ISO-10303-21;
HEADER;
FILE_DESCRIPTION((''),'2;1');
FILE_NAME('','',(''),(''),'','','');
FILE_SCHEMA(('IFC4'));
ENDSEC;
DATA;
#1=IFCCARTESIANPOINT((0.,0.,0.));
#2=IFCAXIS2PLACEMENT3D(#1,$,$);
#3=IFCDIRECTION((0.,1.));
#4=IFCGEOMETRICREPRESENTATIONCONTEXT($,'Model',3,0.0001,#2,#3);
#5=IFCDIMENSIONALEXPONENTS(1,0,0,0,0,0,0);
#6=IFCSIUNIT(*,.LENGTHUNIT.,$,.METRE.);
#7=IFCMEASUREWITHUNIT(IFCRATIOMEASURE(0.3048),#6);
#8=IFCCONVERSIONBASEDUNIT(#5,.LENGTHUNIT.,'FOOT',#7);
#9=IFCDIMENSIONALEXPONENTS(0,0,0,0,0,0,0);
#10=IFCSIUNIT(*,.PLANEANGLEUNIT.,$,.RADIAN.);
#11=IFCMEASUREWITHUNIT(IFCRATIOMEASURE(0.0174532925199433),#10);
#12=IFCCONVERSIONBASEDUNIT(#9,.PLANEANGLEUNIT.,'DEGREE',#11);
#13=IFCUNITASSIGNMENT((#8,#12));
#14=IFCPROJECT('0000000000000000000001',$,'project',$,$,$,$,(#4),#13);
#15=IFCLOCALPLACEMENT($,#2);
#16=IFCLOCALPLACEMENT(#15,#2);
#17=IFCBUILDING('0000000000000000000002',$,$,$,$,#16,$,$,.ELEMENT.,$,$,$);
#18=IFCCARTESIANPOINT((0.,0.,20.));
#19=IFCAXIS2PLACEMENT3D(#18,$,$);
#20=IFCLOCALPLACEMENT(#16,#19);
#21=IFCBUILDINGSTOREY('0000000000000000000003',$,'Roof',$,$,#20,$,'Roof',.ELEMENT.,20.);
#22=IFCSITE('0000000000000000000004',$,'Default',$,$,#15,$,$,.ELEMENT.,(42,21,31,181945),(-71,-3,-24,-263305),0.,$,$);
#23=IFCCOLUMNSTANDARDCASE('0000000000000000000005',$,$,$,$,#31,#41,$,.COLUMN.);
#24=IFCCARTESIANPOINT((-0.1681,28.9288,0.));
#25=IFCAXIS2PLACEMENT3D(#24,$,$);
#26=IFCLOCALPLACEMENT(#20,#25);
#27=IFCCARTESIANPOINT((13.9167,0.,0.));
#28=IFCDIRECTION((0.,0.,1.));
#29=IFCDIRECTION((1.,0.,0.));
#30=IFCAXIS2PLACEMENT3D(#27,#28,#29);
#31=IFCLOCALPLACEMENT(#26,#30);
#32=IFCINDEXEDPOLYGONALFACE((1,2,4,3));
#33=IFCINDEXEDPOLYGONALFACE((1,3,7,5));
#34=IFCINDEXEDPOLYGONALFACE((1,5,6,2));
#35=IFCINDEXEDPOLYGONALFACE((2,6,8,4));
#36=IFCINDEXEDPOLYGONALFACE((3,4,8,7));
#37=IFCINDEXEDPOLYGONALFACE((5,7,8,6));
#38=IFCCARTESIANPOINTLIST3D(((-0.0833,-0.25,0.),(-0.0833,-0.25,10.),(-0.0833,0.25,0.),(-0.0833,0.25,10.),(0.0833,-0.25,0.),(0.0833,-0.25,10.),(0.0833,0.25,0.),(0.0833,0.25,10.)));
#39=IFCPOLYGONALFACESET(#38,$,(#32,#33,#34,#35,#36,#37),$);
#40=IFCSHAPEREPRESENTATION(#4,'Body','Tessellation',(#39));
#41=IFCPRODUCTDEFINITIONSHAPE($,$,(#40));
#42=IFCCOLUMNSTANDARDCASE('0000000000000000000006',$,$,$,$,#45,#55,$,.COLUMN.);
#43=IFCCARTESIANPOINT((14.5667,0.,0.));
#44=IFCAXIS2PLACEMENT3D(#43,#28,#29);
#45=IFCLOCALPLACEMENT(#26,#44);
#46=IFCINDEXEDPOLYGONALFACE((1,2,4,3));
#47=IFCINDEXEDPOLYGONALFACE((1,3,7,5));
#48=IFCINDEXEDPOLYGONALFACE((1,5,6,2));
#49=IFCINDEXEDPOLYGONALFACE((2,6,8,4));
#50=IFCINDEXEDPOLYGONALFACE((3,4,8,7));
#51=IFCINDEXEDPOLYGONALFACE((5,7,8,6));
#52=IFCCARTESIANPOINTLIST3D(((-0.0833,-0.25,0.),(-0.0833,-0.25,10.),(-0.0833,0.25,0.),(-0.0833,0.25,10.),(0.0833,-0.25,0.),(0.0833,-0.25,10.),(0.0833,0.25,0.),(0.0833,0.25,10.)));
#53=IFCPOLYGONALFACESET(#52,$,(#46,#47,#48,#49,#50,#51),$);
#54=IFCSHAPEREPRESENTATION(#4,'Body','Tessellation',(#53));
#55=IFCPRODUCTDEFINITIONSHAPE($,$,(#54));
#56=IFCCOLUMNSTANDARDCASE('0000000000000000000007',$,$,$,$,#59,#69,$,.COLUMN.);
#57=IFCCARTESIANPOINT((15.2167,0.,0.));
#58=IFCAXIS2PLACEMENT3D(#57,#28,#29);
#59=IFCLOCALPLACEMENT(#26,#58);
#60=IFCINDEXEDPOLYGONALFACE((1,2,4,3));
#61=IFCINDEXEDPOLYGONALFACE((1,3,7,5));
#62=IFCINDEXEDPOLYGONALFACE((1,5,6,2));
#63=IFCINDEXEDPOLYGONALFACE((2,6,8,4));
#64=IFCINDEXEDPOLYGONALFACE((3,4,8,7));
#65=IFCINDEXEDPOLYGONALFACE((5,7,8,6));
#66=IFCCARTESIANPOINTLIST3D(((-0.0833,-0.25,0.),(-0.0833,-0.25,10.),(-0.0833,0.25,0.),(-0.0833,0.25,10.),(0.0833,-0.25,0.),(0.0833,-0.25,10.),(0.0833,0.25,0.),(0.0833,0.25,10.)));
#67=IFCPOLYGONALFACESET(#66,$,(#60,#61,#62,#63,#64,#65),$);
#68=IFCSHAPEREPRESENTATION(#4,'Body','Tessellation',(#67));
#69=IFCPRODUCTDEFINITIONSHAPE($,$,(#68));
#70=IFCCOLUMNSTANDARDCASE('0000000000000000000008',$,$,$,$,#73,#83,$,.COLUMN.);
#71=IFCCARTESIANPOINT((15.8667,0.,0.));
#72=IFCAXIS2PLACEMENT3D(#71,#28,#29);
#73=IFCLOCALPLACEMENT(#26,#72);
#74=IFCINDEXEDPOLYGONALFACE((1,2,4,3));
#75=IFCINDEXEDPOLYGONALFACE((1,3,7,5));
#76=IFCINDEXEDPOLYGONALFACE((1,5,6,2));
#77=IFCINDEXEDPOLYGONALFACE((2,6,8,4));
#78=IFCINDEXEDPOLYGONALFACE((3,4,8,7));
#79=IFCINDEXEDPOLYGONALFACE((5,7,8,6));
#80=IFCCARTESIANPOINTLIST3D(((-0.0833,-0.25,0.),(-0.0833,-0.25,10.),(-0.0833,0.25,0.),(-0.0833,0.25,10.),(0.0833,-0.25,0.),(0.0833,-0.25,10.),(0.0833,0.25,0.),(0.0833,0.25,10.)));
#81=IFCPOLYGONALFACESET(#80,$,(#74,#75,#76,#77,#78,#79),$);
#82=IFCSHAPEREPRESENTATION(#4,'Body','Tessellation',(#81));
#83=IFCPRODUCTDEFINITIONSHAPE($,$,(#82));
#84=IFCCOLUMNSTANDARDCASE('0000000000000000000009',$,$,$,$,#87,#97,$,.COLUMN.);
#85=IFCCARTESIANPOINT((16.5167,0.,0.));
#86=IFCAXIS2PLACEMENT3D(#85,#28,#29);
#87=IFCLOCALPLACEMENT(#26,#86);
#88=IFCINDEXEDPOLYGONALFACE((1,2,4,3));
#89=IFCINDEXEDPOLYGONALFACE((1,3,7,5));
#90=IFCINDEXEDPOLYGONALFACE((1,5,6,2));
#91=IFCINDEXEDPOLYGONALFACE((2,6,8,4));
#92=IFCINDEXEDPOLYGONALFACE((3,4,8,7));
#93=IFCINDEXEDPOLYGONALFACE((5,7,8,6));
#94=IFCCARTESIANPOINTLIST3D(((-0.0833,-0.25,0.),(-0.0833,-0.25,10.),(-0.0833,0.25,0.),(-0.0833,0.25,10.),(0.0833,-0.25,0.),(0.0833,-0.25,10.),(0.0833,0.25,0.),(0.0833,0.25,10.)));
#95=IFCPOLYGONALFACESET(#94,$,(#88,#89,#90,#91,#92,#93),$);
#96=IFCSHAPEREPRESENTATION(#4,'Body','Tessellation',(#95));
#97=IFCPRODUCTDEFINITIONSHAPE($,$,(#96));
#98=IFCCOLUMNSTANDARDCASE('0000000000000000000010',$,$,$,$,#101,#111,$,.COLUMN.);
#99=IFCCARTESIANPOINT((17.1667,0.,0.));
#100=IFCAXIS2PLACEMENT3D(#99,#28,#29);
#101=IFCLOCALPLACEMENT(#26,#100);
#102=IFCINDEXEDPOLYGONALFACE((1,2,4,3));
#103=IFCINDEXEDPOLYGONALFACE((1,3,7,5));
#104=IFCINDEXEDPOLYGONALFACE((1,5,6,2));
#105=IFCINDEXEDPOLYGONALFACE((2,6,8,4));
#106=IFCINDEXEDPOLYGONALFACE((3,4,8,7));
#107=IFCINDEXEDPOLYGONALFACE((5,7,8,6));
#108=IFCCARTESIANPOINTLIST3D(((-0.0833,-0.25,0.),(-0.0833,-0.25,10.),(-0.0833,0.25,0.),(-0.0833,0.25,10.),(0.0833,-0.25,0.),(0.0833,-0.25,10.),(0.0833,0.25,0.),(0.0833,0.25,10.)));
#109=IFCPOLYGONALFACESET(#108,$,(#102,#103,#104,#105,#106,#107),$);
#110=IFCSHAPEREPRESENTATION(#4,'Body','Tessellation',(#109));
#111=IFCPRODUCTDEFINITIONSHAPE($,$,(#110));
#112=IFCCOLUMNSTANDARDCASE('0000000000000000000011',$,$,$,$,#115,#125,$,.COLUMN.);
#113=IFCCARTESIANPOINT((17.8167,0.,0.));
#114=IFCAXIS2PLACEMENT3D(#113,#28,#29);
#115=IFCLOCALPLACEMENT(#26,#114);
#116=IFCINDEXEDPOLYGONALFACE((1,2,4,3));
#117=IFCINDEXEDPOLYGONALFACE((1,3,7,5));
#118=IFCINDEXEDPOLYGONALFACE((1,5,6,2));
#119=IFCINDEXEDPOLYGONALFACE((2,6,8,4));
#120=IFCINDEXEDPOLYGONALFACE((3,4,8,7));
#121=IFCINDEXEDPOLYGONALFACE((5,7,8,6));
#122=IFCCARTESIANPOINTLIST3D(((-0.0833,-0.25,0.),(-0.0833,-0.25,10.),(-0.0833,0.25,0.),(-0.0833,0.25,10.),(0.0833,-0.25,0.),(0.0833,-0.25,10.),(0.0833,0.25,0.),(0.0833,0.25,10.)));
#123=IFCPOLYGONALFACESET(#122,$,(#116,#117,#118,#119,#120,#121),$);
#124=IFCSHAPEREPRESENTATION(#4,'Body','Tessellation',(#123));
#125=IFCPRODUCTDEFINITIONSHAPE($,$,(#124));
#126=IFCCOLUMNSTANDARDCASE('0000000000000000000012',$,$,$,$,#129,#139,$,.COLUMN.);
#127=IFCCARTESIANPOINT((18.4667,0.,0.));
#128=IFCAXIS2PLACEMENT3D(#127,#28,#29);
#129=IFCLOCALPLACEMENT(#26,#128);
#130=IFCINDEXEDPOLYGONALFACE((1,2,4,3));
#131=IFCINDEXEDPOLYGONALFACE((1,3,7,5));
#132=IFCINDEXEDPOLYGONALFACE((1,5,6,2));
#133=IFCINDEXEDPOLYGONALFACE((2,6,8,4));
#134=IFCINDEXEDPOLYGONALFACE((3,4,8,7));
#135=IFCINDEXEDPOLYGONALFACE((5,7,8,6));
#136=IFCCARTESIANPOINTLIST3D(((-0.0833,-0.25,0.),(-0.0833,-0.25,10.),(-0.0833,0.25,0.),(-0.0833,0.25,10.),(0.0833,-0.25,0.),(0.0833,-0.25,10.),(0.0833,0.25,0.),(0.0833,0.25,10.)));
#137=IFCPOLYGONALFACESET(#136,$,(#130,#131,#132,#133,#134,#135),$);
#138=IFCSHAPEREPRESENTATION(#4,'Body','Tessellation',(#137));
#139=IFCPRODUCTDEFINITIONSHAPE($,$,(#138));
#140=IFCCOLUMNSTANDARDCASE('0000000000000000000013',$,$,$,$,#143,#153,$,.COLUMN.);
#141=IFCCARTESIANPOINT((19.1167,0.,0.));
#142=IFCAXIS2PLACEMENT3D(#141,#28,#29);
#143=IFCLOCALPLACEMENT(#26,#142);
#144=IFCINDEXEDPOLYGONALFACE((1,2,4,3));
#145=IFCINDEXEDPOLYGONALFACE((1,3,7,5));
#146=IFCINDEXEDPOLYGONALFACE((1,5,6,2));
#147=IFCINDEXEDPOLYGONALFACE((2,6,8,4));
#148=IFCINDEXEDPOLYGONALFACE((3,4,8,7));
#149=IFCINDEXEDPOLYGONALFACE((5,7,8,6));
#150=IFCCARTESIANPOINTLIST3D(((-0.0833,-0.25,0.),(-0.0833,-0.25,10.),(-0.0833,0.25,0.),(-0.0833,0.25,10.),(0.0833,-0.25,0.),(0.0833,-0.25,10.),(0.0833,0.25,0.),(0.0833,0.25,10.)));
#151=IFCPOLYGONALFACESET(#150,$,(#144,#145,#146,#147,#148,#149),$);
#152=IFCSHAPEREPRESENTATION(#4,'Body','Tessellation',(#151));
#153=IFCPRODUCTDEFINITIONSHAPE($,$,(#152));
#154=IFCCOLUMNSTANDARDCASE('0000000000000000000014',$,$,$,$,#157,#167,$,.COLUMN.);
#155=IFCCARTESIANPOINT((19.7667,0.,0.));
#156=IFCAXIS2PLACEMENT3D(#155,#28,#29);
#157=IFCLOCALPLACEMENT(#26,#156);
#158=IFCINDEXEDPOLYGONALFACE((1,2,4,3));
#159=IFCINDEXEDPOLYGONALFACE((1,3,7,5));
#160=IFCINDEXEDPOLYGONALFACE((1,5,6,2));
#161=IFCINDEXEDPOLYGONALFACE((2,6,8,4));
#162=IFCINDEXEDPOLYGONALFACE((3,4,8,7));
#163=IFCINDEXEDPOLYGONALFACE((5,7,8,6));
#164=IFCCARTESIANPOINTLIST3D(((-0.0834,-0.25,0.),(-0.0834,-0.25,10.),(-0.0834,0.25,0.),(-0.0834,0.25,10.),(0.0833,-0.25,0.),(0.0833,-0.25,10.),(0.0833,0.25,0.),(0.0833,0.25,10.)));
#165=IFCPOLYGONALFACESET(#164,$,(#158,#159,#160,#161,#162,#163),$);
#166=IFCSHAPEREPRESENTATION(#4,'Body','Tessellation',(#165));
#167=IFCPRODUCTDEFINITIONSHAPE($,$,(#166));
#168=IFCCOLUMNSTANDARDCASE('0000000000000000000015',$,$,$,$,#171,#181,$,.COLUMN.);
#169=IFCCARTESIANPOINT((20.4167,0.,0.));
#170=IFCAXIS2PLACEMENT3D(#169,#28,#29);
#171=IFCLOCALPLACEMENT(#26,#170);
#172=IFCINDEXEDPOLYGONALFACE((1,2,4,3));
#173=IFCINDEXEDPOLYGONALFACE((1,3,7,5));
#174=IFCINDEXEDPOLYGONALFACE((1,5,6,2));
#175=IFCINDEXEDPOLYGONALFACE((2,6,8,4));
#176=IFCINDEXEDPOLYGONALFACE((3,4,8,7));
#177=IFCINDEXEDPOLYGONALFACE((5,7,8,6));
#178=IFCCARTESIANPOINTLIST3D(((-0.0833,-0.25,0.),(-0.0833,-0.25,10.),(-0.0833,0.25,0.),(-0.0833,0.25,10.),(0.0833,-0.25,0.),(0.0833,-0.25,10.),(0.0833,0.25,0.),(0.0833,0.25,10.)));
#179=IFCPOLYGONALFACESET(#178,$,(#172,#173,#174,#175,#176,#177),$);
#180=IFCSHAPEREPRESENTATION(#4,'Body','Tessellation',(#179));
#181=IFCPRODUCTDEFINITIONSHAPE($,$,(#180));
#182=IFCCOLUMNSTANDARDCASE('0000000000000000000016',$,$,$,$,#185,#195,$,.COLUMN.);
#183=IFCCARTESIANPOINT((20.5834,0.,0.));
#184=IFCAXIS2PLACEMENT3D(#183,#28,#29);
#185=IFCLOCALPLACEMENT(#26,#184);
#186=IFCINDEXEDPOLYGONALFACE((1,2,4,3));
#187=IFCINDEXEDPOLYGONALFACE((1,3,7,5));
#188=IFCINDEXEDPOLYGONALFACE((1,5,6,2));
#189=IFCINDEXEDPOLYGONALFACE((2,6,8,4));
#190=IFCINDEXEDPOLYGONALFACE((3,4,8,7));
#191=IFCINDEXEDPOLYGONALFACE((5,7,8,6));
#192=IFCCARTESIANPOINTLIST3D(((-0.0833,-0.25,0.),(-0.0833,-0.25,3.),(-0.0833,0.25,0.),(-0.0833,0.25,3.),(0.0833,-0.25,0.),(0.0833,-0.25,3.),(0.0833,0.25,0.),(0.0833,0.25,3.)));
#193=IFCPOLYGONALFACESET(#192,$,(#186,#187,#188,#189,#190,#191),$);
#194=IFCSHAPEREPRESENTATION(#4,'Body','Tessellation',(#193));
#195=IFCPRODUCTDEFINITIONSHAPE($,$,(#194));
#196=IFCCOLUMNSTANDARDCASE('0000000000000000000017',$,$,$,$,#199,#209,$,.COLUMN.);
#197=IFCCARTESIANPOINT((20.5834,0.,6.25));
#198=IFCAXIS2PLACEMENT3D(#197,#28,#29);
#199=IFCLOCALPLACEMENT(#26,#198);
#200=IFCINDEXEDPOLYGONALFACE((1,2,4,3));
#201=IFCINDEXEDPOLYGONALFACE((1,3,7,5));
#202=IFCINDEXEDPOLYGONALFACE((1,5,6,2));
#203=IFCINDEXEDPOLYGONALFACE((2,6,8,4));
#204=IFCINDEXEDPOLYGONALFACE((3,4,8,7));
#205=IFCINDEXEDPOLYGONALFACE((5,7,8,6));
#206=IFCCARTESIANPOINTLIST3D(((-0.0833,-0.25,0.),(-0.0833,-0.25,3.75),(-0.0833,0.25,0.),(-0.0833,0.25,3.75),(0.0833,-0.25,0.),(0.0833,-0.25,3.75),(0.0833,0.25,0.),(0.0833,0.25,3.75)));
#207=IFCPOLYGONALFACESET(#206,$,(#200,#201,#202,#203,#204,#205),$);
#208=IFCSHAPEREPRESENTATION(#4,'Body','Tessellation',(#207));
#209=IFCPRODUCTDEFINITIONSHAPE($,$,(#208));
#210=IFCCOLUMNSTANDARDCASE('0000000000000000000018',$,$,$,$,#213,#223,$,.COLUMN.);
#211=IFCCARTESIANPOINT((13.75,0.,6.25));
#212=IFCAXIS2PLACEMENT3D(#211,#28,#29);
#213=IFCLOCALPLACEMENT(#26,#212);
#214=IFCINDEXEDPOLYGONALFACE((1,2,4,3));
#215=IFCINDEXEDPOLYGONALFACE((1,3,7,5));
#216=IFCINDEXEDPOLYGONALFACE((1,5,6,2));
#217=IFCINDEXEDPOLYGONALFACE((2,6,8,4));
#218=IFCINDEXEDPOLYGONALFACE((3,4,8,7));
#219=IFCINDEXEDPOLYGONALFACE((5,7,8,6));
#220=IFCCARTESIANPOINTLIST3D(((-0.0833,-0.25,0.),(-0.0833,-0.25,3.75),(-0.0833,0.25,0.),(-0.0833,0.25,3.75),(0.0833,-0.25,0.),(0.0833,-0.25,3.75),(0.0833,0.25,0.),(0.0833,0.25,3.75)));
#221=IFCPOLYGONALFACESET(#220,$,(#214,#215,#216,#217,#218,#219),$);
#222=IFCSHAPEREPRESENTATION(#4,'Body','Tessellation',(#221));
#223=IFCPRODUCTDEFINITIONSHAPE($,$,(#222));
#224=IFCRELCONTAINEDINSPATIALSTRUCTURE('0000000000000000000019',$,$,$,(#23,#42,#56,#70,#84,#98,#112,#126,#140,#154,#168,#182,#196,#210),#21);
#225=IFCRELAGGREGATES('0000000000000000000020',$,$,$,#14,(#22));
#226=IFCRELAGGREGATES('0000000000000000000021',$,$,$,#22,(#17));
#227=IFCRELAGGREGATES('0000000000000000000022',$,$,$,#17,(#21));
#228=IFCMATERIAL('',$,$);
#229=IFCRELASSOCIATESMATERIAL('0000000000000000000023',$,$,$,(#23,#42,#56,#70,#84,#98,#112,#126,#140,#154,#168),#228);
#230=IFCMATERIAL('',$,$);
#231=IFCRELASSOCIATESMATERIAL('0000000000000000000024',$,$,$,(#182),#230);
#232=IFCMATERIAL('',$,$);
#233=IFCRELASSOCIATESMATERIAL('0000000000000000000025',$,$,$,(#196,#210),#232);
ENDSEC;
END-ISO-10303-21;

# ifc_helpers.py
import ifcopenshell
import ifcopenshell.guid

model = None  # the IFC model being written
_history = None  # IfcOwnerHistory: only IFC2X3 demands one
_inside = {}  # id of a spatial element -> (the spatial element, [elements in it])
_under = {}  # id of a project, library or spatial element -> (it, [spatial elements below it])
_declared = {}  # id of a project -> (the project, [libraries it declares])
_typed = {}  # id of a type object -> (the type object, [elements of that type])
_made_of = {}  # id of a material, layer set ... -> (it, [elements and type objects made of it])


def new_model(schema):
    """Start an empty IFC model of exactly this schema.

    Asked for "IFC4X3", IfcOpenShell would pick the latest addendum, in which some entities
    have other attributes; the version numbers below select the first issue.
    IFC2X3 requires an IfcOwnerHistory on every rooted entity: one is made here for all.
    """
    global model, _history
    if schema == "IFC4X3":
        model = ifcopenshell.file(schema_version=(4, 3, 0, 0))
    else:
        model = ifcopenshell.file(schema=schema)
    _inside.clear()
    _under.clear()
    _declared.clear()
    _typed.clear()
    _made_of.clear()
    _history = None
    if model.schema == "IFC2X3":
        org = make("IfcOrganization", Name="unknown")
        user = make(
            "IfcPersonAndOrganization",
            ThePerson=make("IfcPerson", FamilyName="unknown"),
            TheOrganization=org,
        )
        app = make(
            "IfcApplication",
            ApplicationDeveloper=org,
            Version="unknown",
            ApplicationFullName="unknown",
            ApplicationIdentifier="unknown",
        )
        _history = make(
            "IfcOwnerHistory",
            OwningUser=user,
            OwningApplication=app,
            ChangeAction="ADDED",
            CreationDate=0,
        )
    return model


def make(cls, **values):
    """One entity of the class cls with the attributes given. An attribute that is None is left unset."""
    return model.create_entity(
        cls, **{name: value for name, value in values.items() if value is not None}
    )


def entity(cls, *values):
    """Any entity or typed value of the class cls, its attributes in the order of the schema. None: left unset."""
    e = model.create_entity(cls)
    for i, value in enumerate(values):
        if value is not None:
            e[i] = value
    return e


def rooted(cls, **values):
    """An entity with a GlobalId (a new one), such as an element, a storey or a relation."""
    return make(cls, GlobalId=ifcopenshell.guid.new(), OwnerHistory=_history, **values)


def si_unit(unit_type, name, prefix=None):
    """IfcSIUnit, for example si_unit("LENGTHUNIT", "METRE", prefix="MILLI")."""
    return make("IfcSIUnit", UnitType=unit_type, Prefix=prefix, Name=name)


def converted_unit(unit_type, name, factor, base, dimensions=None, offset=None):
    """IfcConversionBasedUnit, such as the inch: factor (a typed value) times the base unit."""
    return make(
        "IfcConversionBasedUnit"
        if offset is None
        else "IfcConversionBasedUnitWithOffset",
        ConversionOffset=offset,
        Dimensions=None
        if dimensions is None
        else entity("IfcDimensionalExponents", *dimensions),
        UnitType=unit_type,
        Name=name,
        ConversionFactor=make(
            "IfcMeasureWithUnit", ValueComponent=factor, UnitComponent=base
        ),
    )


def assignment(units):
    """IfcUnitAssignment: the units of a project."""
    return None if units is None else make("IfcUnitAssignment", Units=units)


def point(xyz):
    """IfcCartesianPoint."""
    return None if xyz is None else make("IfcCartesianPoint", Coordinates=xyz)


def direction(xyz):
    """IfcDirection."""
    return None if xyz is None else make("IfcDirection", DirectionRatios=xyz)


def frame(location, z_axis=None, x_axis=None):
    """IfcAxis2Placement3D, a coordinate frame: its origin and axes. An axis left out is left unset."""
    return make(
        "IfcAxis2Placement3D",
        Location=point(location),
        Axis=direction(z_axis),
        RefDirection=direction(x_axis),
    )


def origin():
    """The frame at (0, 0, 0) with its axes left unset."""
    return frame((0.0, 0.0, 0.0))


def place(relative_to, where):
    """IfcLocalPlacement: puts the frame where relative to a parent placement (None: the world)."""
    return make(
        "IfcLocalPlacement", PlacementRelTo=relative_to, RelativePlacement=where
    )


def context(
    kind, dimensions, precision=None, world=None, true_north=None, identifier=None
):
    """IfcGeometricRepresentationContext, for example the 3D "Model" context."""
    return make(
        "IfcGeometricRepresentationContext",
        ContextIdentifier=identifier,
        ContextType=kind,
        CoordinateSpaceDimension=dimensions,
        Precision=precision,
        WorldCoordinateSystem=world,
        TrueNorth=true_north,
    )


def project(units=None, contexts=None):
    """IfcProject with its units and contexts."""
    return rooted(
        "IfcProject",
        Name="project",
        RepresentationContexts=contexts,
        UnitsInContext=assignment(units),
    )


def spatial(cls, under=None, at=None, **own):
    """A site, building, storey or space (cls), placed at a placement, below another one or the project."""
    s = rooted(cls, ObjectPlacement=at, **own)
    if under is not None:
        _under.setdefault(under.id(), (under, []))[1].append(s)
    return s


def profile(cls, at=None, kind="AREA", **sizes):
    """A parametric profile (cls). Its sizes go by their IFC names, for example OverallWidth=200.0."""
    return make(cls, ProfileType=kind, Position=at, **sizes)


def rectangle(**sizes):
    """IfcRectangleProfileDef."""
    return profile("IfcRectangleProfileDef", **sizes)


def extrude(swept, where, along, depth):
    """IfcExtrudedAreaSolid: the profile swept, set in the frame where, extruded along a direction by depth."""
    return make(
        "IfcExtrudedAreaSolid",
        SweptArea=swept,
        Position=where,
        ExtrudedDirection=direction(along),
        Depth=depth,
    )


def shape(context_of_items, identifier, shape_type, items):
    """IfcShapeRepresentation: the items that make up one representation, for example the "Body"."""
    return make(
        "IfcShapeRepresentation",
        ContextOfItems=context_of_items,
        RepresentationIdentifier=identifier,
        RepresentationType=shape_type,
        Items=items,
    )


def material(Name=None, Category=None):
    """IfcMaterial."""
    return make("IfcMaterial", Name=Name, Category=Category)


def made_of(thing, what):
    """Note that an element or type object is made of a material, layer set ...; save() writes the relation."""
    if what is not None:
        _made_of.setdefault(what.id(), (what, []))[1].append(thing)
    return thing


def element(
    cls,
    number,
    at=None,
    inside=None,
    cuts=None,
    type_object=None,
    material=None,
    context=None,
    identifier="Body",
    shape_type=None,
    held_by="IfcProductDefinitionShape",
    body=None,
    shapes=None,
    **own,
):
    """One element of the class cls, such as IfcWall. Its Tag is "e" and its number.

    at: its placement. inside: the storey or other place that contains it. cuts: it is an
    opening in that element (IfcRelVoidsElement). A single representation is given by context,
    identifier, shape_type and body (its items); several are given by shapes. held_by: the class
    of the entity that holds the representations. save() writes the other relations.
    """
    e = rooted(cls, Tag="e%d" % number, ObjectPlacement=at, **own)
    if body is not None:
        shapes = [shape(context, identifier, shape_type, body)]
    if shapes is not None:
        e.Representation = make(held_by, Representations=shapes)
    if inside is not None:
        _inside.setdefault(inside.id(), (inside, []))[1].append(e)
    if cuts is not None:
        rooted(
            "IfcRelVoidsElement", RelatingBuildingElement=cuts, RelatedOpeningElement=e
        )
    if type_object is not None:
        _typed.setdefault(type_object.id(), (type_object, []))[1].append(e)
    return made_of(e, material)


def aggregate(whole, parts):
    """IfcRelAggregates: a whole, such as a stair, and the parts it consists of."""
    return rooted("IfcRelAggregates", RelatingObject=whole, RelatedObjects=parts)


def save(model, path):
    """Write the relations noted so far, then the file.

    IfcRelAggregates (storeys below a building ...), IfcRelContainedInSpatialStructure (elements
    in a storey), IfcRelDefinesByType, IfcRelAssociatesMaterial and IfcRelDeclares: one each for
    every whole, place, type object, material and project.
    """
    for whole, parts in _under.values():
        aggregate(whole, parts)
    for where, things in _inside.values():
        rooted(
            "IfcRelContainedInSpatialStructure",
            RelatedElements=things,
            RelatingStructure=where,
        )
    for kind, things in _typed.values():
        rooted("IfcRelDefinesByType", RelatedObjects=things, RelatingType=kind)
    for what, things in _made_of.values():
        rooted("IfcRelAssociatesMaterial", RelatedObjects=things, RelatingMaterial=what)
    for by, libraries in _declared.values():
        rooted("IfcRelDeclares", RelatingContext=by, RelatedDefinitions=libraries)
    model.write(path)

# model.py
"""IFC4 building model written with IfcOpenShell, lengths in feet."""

from ifc_helpers import new_model, entity, si_unit, converted_unit, direction, frame, origin, place, context, project, spatial, rectangle, extrude, material, element, save


model = new_model("IFC4")

# Units and contexts
model_context = context("Model", 3, precision=0.0001, world=origin(), true_north=direction((0.0, 1.0)))
ifc_project = project(units=[converted_unit("LENGTHUNIT", "FOOT", entity("IfcRatioMeasure", 0.3048), si_unit("LENGTHUNIT", "METRE"), dimensions=[1, 0, 0, 0, 0, 0, 0]), converted_unit("PLANEANGLEUNIT", "DEGREE", entity("IfcRatioMeasure", 0.0174532925199433), si_unit("PLANEANGLEUNIT", "RADIAN"), dimensions=[0, 0, 0, 0, 0, 0, 0])], contexts=[model_context])

# Site, building, storey
site_placement = place(None, origin())
site = spatial("IfcSite", under=ifc_project, at=site_placement, Name="Default", CompositionType="ELEMENT", RefLatitude=(42, 21, 31, 181945), RefLongitude=(-71, -3, -24, -263305), RefElevation=0.0)
building_placement = place(site_placement, origin())
building = spatial("IfcBuilding", under=site, at=building_placement, CompositionType="ELEMENT")
storey_placement = place(building_placement, frame((0.0, 0.0, 20.0)))
storey = spatial("IfcBuildingStorey", under=building, at=storey_placement, Name="Roof", LongName="Roof", CompositionType="ELEMENT", Elevation=20.0)

# Columns
ifc_material_1 = material(Name="")
placement = place(storey_placement, frame((-0.1681, 28.9288, 0.0)))
for number, where, z_axis, x_axis in (
    (1, (13.9167, 0.0, 0.0), (0.0, 0.0, 1.0), (1.0, 0.0, 0.0)),
    (2, (14.5667, 0.0, 0.0), (0.0, 0.0, 1.0), (1.0, 0.0, 0.0)),
    (3, (15.2167, 0.0, 0.0), (0.0, 0.0, 1.0), (1.0, 0.0, 0.0)),
    (4, (15.8667, 0.0, 0.0), (0.0, 0.0, 1.0), (1.0, 0.0, 0.0)),
    (5, (16.5167, 0.0, 0.0), (0.0, 0.0, 1.0), (1.0, 0.0, 0.0)),
    (6, (17.1667, 0.0, 0.0), (0.0, 0.0, 1.0), (1.0, 0.0, 0.0)),
    (7, (17.8167, 0.0, 0.0), (0.0, 0.0, 1.0), (1.0, 0.0, 0.0)),
    (8, (18.4667, 0.0, 0.0), (0.0, 0.0, 1.0), (1.0, 0.0, 0.0)),
    (9, (19.1167, 0.0, 0.0), (0.0, 0.0, 1.0), (1.0, 0.0, 0.0)),
    (10, (19.7667, 0.0, 0.0), (0.0, 0.0, 1.0), (1.0, 0.0, 0.0)),
    (11, (20.4167, 0.0, 0.0), (0.0, 0.0, 1.0), (1.0, 0.0, 0.0)),
):
    element("IfcColumnStandardCase", number, at=place(placement, frame(where, z_axis=z_axis, x_axis=x_axis)), inside=storey, material=ifc_material_1, PredefinedType="COLUMN", context=model_context, shape_type="SweptSolid", body=[
        extrude(rectangle(XDim=0.1667, YDim=0.5), origin(), (0.0, 0.0, 1.0), 10.0),
    ])
ifc_material_2 = material(Name="")
for number, where, z_axis, x_axis in (
    (12, (20.5834, 0.0, 0.0), (0.0, 0.0, 1.0), (1.0, 0.0, 0.0)),
):
    element("IfcColumnStandardCase", number, at=place(placement, frame(where, z_axis=z_axis, x_axis=x_axis)), inside=storey, material=ifc_material_2, PredefinedType="COLUMN", context=model_context, shape_type="SweptSolid", body=[
        extrude(rectangle(XDim=0.1667, YDim=0.5), origin(), (0.0, 0.0, 1.0), 3.0),
    ])
ifc_material_3 = material(Name="")
for number, where, z_axis, x_axis in (
    (13, (20.5834, 0.0, 6.25), (0.0, 0.0, 1.0), (1.0, 0.0, 0.0)),
    (14, (13.75, 0.0, 6.25), (0.0, 0.0, 1.0), (1.0, 0.0, 0.0)),
):
    element("IfcColumnStandardCase", number, at=place(placement, frame(where, z_axis=z_axis, x_axis=x_axis)), inside=storey, material=ifc_material_3, PredefinedType="COLUMN", context=model_context, shape_type="SweptSolid", body=[
        extrude(rectangle(XDim=0.1667, YDim=0.5), origin(), (0.0, 0.0, 1.0), 3.75),
    ])

save(model, "model.ifc")
